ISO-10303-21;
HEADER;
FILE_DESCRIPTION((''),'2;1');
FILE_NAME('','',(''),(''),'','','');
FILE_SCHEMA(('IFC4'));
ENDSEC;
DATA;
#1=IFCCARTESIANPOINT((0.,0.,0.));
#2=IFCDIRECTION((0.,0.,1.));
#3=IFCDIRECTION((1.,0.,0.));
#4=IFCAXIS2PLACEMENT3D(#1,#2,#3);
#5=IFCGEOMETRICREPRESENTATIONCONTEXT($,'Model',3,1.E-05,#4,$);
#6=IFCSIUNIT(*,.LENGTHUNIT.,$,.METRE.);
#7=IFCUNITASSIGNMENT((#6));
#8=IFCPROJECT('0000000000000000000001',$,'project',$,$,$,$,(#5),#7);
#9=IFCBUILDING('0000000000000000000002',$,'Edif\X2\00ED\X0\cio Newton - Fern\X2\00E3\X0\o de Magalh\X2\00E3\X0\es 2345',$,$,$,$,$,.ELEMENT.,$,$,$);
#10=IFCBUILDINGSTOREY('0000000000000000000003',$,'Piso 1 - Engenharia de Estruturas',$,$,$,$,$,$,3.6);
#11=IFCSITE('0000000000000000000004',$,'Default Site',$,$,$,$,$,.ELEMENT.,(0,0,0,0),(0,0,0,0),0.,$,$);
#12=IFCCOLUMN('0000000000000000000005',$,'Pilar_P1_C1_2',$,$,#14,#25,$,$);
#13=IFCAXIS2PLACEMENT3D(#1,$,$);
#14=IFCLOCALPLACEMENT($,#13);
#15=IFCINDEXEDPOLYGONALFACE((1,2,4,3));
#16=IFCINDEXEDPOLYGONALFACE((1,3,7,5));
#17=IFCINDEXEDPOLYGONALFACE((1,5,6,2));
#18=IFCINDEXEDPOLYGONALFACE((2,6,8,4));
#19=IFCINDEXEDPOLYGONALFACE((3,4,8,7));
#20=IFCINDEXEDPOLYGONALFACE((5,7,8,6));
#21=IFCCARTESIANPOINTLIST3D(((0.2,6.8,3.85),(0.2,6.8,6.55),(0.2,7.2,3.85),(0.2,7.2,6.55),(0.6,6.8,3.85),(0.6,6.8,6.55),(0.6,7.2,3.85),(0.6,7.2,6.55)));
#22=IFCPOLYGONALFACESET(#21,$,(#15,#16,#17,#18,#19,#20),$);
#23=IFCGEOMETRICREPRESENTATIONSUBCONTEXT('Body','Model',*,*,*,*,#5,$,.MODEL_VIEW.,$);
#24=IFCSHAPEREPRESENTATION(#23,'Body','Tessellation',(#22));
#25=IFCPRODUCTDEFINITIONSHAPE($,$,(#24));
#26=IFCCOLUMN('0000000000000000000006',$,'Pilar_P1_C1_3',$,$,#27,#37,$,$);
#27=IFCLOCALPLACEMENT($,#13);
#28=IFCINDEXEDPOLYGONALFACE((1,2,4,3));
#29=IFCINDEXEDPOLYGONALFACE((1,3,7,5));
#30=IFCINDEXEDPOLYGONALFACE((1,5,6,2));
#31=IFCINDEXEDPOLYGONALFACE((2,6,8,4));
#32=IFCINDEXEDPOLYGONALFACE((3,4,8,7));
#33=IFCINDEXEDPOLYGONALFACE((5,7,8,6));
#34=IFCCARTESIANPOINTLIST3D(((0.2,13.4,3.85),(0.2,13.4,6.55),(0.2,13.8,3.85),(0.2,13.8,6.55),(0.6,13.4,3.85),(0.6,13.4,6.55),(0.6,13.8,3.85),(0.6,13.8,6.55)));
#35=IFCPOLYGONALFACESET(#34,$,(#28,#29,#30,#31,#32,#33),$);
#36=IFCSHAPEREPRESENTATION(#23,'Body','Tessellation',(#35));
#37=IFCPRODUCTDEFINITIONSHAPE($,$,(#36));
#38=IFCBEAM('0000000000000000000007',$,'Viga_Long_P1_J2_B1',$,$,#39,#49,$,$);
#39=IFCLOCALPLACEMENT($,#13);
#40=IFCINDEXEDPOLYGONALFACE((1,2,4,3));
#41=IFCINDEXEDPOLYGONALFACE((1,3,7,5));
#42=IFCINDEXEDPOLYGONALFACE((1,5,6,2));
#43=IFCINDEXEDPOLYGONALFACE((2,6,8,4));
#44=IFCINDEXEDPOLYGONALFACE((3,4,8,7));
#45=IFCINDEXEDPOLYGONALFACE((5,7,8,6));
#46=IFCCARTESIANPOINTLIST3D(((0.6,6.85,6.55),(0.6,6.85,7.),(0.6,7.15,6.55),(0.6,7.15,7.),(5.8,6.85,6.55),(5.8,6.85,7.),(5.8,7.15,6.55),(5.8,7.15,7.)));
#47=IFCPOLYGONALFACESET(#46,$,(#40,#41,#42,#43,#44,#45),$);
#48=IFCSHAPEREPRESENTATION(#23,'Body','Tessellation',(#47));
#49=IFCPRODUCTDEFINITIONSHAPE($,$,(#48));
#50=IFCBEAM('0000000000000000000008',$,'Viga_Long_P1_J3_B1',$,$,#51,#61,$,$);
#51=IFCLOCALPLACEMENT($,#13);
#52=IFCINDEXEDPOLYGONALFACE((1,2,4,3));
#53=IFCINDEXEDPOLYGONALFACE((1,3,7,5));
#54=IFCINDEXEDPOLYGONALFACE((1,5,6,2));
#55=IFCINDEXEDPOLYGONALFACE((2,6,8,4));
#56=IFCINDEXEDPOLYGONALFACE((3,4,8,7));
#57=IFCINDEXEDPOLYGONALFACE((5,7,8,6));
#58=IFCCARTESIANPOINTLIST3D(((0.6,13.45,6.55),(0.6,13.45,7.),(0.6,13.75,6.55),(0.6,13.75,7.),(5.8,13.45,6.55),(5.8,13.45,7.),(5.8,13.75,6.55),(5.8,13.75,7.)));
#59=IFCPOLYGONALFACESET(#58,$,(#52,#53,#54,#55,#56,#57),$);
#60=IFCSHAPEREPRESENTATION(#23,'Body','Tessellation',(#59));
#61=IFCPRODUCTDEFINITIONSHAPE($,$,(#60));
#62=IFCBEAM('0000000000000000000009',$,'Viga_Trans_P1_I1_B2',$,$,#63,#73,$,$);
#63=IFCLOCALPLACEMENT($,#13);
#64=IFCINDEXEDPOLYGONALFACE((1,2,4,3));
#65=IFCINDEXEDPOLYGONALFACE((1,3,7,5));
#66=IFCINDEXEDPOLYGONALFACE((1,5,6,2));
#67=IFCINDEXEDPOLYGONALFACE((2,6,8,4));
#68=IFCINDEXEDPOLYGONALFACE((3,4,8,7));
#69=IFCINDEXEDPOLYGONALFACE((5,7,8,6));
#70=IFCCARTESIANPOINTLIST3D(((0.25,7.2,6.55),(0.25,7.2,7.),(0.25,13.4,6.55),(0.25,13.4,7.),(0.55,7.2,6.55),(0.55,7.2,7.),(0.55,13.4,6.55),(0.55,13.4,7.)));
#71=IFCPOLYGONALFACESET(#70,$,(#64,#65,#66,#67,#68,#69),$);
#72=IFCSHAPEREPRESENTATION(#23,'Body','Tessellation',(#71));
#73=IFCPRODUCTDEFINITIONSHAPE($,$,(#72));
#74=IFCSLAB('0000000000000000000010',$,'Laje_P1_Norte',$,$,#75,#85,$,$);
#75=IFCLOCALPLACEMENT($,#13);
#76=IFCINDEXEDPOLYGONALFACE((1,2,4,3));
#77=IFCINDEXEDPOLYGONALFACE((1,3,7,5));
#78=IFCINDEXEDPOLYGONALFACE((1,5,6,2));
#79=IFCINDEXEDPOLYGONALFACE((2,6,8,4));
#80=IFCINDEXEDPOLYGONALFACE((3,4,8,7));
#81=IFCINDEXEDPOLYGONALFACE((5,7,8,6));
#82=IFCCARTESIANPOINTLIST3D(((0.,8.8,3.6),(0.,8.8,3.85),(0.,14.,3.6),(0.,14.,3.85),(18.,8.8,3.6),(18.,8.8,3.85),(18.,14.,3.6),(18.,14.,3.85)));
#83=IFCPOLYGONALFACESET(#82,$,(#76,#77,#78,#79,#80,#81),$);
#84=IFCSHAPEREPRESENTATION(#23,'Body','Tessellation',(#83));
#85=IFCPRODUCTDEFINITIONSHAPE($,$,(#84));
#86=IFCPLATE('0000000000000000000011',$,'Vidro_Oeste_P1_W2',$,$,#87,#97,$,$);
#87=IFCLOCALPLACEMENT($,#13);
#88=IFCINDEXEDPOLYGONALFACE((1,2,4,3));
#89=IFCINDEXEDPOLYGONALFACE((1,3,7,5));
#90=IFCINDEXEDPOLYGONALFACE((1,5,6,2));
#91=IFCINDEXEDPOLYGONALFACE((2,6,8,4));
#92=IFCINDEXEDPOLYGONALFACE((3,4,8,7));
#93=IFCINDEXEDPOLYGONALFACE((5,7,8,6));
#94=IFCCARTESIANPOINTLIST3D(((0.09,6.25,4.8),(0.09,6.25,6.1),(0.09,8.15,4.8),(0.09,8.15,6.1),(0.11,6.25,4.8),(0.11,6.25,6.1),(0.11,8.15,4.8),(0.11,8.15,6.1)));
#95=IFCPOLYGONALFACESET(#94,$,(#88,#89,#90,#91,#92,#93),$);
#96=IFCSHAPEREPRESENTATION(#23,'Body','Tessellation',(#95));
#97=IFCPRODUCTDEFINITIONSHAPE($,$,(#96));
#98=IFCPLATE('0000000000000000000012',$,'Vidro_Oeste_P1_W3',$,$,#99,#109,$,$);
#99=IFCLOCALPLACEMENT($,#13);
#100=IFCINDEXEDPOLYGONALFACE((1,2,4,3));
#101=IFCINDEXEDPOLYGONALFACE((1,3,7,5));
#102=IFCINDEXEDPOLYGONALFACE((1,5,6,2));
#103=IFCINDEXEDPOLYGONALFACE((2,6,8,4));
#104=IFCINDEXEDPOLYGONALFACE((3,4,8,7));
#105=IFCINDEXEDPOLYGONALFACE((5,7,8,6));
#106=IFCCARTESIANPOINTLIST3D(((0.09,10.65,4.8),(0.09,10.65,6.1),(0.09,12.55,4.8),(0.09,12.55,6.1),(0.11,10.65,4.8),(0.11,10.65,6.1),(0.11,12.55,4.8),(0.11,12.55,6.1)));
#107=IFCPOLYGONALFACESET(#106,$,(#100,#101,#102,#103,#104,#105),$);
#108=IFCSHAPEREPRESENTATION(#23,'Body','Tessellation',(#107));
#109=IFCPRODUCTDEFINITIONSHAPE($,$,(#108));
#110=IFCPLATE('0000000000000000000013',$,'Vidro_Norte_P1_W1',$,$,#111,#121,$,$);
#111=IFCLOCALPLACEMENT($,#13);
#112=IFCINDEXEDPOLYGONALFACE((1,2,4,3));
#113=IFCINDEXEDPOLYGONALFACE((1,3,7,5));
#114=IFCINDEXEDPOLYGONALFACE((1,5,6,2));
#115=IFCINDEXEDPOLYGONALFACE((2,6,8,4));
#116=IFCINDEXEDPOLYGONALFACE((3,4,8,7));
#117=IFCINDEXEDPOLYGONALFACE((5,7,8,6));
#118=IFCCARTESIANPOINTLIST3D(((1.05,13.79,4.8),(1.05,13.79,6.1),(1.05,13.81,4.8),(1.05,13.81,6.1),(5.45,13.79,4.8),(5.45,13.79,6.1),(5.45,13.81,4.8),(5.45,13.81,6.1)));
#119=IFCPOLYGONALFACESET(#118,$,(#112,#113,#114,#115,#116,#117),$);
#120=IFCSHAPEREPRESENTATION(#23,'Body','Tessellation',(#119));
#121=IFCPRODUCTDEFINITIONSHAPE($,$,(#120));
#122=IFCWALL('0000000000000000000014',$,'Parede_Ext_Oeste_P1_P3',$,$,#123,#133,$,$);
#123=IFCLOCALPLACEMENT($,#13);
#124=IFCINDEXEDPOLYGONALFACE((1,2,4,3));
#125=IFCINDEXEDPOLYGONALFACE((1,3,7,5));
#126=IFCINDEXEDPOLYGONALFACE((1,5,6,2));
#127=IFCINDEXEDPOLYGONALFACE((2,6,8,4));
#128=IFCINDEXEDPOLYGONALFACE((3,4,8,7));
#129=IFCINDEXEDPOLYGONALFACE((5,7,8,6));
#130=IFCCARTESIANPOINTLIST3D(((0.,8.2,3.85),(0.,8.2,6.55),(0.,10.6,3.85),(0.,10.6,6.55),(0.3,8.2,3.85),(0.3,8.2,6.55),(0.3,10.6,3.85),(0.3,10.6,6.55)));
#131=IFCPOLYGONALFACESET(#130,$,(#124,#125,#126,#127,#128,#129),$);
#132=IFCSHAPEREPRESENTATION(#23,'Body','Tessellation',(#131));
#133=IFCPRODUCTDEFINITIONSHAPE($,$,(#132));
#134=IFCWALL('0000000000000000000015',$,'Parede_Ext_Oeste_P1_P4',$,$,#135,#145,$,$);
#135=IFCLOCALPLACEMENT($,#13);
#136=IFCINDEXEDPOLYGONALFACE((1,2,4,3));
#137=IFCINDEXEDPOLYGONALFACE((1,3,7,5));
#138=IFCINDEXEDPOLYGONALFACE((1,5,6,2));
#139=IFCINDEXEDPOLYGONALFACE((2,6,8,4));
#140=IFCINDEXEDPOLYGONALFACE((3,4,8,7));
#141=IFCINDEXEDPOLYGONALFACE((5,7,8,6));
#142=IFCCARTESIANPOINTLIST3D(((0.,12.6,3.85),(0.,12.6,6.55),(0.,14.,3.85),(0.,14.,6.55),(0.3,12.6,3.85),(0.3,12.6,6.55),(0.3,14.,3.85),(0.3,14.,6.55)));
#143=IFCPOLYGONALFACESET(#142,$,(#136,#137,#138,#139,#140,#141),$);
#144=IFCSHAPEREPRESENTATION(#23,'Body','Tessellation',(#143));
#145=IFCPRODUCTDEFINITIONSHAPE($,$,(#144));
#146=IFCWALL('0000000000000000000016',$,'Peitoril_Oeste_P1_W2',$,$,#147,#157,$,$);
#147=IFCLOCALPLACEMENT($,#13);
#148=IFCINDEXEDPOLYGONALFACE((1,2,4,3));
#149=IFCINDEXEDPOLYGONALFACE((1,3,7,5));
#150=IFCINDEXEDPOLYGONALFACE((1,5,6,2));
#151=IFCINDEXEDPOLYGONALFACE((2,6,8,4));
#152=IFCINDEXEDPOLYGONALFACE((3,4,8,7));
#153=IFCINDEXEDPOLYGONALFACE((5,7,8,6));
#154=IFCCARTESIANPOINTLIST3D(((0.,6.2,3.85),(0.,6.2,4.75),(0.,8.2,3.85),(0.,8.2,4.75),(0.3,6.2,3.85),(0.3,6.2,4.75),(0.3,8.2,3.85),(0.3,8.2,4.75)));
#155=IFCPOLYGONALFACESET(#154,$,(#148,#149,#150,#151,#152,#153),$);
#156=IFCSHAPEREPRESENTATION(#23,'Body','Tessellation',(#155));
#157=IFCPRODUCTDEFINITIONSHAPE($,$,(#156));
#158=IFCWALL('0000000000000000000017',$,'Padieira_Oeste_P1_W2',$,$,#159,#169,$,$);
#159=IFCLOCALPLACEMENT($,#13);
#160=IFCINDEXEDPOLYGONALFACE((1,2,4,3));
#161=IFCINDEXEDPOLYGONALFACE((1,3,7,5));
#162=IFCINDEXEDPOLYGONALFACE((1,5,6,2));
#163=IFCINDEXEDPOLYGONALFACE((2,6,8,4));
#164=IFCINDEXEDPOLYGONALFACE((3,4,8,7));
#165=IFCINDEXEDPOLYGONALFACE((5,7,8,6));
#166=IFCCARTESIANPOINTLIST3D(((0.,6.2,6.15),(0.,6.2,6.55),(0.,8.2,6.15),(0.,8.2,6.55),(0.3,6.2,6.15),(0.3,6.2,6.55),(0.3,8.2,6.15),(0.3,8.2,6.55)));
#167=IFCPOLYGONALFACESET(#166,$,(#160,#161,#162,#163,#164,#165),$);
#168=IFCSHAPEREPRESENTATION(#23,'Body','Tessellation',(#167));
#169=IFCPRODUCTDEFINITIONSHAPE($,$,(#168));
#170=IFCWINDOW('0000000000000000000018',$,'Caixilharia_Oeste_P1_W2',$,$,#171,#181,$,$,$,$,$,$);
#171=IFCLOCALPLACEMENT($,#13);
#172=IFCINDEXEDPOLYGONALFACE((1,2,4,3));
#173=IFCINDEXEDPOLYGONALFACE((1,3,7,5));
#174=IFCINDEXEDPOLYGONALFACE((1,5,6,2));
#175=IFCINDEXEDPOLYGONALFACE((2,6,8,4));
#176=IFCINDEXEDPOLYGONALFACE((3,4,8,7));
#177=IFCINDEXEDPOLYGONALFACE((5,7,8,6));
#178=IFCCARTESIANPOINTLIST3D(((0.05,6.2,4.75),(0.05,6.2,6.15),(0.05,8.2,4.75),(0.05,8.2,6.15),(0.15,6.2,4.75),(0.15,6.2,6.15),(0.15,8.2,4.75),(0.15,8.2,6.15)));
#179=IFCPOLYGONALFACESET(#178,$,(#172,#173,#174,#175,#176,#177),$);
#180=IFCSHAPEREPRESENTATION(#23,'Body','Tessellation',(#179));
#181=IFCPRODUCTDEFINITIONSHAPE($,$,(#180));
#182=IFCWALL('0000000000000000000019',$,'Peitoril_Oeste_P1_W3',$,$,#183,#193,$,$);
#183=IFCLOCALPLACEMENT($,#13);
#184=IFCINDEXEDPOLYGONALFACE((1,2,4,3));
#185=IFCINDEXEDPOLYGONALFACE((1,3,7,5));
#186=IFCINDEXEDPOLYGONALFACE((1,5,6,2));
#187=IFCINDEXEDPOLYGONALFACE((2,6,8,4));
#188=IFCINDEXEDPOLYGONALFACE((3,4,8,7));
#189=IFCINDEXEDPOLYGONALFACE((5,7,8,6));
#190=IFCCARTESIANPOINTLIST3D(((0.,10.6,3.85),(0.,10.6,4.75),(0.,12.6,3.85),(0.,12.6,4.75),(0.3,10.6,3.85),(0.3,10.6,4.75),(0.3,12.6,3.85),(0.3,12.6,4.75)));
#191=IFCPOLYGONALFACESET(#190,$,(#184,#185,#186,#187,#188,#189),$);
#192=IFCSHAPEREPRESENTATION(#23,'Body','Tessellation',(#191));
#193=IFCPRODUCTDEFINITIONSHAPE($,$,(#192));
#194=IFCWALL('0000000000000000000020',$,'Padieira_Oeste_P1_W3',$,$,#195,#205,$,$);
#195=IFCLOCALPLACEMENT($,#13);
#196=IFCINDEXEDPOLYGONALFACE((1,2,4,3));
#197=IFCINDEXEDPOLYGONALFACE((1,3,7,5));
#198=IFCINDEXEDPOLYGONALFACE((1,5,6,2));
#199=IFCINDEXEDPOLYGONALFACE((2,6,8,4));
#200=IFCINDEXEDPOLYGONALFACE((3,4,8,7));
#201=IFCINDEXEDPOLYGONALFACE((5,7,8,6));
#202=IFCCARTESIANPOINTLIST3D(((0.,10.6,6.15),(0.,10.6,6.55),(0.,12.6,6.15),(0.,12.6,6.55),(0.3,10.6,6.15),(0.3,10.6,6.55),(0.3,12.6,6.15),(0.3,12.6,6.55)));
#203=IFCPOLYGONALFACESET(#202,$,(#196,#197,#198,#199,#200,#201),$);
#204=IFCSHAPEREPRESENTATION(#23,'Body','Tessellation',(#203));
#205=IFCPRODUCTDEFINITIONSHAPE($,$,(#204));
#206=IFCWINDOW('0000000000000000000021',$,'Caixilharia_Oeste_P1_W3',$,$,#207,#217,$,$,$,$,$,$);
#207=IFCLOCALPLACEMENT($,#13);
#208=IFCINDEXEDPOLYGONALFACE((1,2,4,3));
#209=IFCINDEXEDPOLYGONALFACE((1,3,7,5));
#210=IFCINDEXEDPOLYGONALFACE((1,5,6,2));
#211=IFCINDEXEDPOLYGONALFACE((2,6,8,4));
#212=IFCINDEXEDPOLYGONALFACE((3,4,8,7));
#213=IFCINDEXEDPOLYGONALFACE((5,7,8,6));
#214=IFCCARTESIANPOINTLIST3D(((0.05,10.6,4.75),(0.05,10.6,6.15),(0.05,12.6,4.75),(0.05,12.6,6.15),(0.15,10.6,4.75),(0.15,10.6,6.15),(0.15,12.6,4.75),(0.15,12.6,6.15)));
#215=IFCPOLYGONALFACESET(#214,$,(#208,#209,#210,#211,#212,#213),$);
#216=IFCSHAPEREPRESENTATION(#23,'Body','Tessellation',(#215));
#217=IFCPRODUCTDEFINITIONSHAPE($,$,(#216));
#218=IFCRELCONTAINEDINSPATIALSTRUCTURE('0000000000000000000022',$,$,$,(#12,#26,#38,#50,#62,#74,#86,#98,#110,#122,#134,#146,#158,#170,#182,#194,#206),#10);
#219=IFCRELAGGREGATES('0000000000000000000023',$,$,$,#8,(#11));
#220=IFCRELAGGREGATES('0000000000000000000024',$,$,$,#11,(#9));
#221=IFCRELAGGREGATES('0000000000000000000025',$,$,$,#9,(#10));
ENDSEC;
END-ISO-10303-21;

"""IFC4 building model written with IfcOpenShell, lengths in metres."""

from ifc_helpers import new_model, si_unit, frame, frame_2d, origin_with_axes, place, context, subcontext, project, spatial, rectangle, extrude, element, save


model = new_model("IFC4")

# Units and contexts
model_context = context("Model", 3, precision=1e-05, world=origin_with_axes())
body_context = subcontext(model_context, "Body", "Model", "MODEL_VIEW")
ifc_project = project(units=[si_unit("LENGTHUNIT", "METRE")], contexts=[model_context])

# Site, building, storey
site = spatial("IfcSite", under=ifc_project, Name="Default Site", CompositionType="ELEMENT", RefLatitude=(0, 0, 0, 0), RefLongitude=(0, 0, 0, 0), RefElevation=0.0)
building = spatial("IfcBuilding", under=site, Name="Edifício Newton - Fernão de Magalhães 2345", CompositionType="ELEMENT")
storey = spatial("IfcBuildingStorey", under=building, Name="Piso 1 - Engenharia de Estruturas", Elevation=3.6)

# Columns
for number, where, z_axis, x_axis, name in (
    (1, (0.2, 6.8, 3.85), (0.0, 0.0, 1.0), (1.0, 0.0, 0.0), "Pilar_P1_C1_2"),
    (2, (0.2, 13.4, 3.85), (0.0, 0.0, 1.0), (1.0, 0.0, 0.0), "Pilar_P1_C1_3"),
):
    element("IfcColumn", number, at=place(None, frame(where, z_axis=z_axis, x_axis=x_axis)), inside=storey, Name=name, context=body_context, shape_type="SweptSolid", body=[
        extrude(rectangle(XDim=0.4, YDim=0.4, at=frame_2d((0.2, 0.2))), origin_with_axes(), (0.0, 0.0, 1.0), 2.7),
    ])

# Beams
for number, where, z_axis, x_axis, name in (
    (3, (0.6, 6.85, 6.55), (0.0, 0.0, 1.0), (1.0, 0.0, 0.0), "Viga_Long_P1_J2_B1"),
    (4, (0.6, 13.45, 6.55), (0.0, 0.0, 1.0), (1.0, 0.0, 0.0), "Viga_Long_P1_J3_B1"),
):
    element("IfcBeam", number, at=place(None, frame(where, z_axis=z_axis, x_axis=x_axis)), inside=storey, Name=name, context=body_context, shape_type="SweptSolid", body=[
        extrude(rectangle(XDim=5.2, YDim=0.3, at=frame_2d((2.6, 0.15))), origin_with_axes(), (0.0, 0.0, 1.0), 0.45),
    ])
beam_placement = place(None, frame((0.25, 7.2, 6.55), z_axis=(0.0, 0.0, 1.0), x_axis=(1.0, 0.0, 0.0)))
element("IfcBeam", 5, at=beam_placement, inside=storey, Name="Viga_Trans_P1_I1_B2", context=body_context, shape_type="SweptSolid", body=[
    extrude(rectangle(XDim=0.3, YDim=6.2, at=frame_2d((0.15, 3.1))), origin_with_axes(), (0.0, 0.0, 1.0), 0.45),
])

# Slab
slab_placement = place(None, frame((0.0, 8.8, 3.6), z_axis=(0.0, 0.0, 1.0), x_axis=(1.0, 0.0, 0.0)))
element("IfcSlab", 6, at=slab_placement, inside=storey, Name="Laje_P1_Norte", context=body_context, shape_type="SweptSolid", body=[
    extrude(rectangle(XDim=18.0, YDim=5.2, at=frame_2d((9.0, 2.6))), origin_with_axes(), (0.0, 0.0, 1.0), 0.25),
])

# Plates
plate_1_placement = place(None, frame((0.09, 6.25, 4.8), z_axis=(0.0, 0.0, 1.0), x_axis=(1.0, 0.0, 0.0)))
element("IfcPlate", 7, at=plate_1_placement, inside=storey, Name="Vidro_Oeste_P1_W2", context=body_context, shape_type="SweptSolid", body=[
    extrude(rectangle(XDim=0.02, YDim=1.9, at=frame_2d((0.01, 0.95))), origin_with_axes(), (0.0, 0.0, 1.0), 1.3),
])
plate_2_placement = place(None, frame((0.09, 10.65, 4.8), z_axis=(0.0, 0.0, 1.0), x_axis=(1.0, 0.0, 0.0)))
element("IfcPlate", 8, at=plate_2_placement, inside=storey, Name="Vidro_Oeste_P1_W3", context=body_context, shape_type="SweptSolid", body=[
    extrude(rectangle(XDim=0.02, YDim=1.9, at=frame_2d((0.01, 0.95))), origin_with_axes(), (0.0, 0.0, 1.0), 1.3),
])
plate_3_placement = place(None, frame((1.05, 13.79, 4.8), z_axis=(0.0, 0.0, 1.0), x_axis=(1.0, 0.0, 0.0)))
element("IfcPlate", 9, at=plate_3_placement, inside=storey, Name="Vidro_Norte_P1_W1", context=body_context, shape_type="SweptSolid", body=[
    extrude(rectangle(XDim=4.4, YDim=0.02, at=frame_2d((2.2, 0.01))), origin_with_axes(), (0.0, 0.0, 1.0), 1.3),
])

# Walls
wall_1_placement = place(None, frame((0.0, 8.2, 3.85), z_axis=(0.0, 0.0, 1.0), x_axis=(1.0, 0.0, 0.0)))
element("IfcWall", 10, at=wall_1_placement, inside=storey, Name="Parede_Ext_Oeste_P1_P3", context=body_context, shape_type="SweptSolid", body=[
    extrude(rectangle(XDim=0.3, YDim=2.4, at=frame_2d((0.15, 1.2))), origin_with_axes(), (0.0, 0.0, 1.0), 2.7),
])
wall_2_placement = place(None, frame((0.0, 12.6, 3.85), z_axis=(0.0, 0.0, 1.0), x_axis=(1.0, 0.0, 0.0)))
element("IfcWall", 11, at=wall_2_placement, inside=storey, Name="Parede_Ext_Oeste_P1_P4", context=body_context, shape_type="SweptSolid", body=[
    extrude(rectangle(XDim=0.3, YDim=1.4, at=frame_2d((0.15, 0.7))), origin_with_axes(), (0.0, 0.0, 1.0), 2.7),
])
wall_3_placement = place(None, frame((0.0, 6.2, 3.85), z_axis=(0.0, 0.0, 1.0), x_axis=(1.0, 0.0, 0.0)))
element("IfcWall", 12, at=wall_3_placement, inside=storey, Name="Peitoril_Oeste_P1_W2", context=body_context, shape_type="SweptSolid", body=[
    extrude(rectangle(XDim=0.3, YDim=2.0, at=frame_2d((0.15, 1.0))), origin_with_axes(), (0.0, 0.0, 1.0), 0.9),
])
wall_4_placement = place(None, frame((0.0, 6.2, 6.15), z_axis=(0.0, 0.0, 1.0), x_axis=(1.0, 0.0, 0.0)))
element("IfcWall", 13, at=wall_4_placement, inside=storey, Name="Padieira_Oeste_P1_W2", context=body_context, shape_type="SweptSolid", body=[
    extrude(rectangle(XDim=0.3, YDim=2.0, at=frame_2d((0.15, 1.0))), origin_with_axes(), (0.0, 0.0, 1.0), 0.4),
])

# Window
window_1_placement = place(None, frame((0.05, 6.2, 4.75), z_axis=(0.0, 0.0, 1.0), x_axis=(1.0, 0.0, 0.0)))
element("IfcWindow", 14, at=window_1_placement, inside=storey, Name="Caixilharia_Oeste_P1_W2", context=body_context, shape_type="SweptSolid", body=[
    extrude(rectangle(XDim=0.1, YDim=2.0, at=frame_2d((0.05, 1.0))), origin_with_axes(), (0.0, 0.0, 1.0), 1.4),
])

# Walls
wall_5_placement = place(None, frame((0.0, 10.6, 3.85), z_axis=(0.0, 0.0, 1.0), x_axis=(1.0, 0.0, 0.0)))
element("IfcWall", 15, at=wall_5_placement, inside=storey, Name="Peitoril_Oeste_P1_W3", context=body_context, shape_type="SweptSolid", body=[
    extrude(rectangle(XDim=0.3, YDim=2.0, at=frame_2d((0.15, 1.0))), origin_with_axes(), (0.0, 0.0, 1.0), 0.9),
])
wall_6_placement = place(None, frame((0.0, 10.6, 6.15), z_axis=(0.0, 0.0, 1.0), x_axis=(1.0, 0.0, 0.0)))
element("IfcWall", 16, at=wall_6_placement, inside=storey, Name="Padieira_Oeste_P1_W3", context=body_context, shape_type="SweptSolid", body=[
    extrude(rectangle(XDim=0.3, YDim=2.0, at=frame_2d((0.15, 1.0))), origin_with_axes(), (0.0, 0.0, 1.0), 0.4),
])

# Window
window_2_placement = place(None, frame((0.05, 10.6, 4.75), z_axis=(0.0, 0.0, 1.0), x_axis=(1.0, 0.0, 0.0)))
element("IfcWindow", 17, at=window_2_placement, inside=storey, Name="Caixilharia_Oeste_P1_W3", context=body_context, shape_type="SweptSolid", body=[
    extrude(rectangle(XDim=0.1, YDim=2.0, at=frame_2d((0.05, 1.0))), origin_with_axes(), (0.0, 0.0, 1.0), 1.4),
])

save(model, "model.ifc")
